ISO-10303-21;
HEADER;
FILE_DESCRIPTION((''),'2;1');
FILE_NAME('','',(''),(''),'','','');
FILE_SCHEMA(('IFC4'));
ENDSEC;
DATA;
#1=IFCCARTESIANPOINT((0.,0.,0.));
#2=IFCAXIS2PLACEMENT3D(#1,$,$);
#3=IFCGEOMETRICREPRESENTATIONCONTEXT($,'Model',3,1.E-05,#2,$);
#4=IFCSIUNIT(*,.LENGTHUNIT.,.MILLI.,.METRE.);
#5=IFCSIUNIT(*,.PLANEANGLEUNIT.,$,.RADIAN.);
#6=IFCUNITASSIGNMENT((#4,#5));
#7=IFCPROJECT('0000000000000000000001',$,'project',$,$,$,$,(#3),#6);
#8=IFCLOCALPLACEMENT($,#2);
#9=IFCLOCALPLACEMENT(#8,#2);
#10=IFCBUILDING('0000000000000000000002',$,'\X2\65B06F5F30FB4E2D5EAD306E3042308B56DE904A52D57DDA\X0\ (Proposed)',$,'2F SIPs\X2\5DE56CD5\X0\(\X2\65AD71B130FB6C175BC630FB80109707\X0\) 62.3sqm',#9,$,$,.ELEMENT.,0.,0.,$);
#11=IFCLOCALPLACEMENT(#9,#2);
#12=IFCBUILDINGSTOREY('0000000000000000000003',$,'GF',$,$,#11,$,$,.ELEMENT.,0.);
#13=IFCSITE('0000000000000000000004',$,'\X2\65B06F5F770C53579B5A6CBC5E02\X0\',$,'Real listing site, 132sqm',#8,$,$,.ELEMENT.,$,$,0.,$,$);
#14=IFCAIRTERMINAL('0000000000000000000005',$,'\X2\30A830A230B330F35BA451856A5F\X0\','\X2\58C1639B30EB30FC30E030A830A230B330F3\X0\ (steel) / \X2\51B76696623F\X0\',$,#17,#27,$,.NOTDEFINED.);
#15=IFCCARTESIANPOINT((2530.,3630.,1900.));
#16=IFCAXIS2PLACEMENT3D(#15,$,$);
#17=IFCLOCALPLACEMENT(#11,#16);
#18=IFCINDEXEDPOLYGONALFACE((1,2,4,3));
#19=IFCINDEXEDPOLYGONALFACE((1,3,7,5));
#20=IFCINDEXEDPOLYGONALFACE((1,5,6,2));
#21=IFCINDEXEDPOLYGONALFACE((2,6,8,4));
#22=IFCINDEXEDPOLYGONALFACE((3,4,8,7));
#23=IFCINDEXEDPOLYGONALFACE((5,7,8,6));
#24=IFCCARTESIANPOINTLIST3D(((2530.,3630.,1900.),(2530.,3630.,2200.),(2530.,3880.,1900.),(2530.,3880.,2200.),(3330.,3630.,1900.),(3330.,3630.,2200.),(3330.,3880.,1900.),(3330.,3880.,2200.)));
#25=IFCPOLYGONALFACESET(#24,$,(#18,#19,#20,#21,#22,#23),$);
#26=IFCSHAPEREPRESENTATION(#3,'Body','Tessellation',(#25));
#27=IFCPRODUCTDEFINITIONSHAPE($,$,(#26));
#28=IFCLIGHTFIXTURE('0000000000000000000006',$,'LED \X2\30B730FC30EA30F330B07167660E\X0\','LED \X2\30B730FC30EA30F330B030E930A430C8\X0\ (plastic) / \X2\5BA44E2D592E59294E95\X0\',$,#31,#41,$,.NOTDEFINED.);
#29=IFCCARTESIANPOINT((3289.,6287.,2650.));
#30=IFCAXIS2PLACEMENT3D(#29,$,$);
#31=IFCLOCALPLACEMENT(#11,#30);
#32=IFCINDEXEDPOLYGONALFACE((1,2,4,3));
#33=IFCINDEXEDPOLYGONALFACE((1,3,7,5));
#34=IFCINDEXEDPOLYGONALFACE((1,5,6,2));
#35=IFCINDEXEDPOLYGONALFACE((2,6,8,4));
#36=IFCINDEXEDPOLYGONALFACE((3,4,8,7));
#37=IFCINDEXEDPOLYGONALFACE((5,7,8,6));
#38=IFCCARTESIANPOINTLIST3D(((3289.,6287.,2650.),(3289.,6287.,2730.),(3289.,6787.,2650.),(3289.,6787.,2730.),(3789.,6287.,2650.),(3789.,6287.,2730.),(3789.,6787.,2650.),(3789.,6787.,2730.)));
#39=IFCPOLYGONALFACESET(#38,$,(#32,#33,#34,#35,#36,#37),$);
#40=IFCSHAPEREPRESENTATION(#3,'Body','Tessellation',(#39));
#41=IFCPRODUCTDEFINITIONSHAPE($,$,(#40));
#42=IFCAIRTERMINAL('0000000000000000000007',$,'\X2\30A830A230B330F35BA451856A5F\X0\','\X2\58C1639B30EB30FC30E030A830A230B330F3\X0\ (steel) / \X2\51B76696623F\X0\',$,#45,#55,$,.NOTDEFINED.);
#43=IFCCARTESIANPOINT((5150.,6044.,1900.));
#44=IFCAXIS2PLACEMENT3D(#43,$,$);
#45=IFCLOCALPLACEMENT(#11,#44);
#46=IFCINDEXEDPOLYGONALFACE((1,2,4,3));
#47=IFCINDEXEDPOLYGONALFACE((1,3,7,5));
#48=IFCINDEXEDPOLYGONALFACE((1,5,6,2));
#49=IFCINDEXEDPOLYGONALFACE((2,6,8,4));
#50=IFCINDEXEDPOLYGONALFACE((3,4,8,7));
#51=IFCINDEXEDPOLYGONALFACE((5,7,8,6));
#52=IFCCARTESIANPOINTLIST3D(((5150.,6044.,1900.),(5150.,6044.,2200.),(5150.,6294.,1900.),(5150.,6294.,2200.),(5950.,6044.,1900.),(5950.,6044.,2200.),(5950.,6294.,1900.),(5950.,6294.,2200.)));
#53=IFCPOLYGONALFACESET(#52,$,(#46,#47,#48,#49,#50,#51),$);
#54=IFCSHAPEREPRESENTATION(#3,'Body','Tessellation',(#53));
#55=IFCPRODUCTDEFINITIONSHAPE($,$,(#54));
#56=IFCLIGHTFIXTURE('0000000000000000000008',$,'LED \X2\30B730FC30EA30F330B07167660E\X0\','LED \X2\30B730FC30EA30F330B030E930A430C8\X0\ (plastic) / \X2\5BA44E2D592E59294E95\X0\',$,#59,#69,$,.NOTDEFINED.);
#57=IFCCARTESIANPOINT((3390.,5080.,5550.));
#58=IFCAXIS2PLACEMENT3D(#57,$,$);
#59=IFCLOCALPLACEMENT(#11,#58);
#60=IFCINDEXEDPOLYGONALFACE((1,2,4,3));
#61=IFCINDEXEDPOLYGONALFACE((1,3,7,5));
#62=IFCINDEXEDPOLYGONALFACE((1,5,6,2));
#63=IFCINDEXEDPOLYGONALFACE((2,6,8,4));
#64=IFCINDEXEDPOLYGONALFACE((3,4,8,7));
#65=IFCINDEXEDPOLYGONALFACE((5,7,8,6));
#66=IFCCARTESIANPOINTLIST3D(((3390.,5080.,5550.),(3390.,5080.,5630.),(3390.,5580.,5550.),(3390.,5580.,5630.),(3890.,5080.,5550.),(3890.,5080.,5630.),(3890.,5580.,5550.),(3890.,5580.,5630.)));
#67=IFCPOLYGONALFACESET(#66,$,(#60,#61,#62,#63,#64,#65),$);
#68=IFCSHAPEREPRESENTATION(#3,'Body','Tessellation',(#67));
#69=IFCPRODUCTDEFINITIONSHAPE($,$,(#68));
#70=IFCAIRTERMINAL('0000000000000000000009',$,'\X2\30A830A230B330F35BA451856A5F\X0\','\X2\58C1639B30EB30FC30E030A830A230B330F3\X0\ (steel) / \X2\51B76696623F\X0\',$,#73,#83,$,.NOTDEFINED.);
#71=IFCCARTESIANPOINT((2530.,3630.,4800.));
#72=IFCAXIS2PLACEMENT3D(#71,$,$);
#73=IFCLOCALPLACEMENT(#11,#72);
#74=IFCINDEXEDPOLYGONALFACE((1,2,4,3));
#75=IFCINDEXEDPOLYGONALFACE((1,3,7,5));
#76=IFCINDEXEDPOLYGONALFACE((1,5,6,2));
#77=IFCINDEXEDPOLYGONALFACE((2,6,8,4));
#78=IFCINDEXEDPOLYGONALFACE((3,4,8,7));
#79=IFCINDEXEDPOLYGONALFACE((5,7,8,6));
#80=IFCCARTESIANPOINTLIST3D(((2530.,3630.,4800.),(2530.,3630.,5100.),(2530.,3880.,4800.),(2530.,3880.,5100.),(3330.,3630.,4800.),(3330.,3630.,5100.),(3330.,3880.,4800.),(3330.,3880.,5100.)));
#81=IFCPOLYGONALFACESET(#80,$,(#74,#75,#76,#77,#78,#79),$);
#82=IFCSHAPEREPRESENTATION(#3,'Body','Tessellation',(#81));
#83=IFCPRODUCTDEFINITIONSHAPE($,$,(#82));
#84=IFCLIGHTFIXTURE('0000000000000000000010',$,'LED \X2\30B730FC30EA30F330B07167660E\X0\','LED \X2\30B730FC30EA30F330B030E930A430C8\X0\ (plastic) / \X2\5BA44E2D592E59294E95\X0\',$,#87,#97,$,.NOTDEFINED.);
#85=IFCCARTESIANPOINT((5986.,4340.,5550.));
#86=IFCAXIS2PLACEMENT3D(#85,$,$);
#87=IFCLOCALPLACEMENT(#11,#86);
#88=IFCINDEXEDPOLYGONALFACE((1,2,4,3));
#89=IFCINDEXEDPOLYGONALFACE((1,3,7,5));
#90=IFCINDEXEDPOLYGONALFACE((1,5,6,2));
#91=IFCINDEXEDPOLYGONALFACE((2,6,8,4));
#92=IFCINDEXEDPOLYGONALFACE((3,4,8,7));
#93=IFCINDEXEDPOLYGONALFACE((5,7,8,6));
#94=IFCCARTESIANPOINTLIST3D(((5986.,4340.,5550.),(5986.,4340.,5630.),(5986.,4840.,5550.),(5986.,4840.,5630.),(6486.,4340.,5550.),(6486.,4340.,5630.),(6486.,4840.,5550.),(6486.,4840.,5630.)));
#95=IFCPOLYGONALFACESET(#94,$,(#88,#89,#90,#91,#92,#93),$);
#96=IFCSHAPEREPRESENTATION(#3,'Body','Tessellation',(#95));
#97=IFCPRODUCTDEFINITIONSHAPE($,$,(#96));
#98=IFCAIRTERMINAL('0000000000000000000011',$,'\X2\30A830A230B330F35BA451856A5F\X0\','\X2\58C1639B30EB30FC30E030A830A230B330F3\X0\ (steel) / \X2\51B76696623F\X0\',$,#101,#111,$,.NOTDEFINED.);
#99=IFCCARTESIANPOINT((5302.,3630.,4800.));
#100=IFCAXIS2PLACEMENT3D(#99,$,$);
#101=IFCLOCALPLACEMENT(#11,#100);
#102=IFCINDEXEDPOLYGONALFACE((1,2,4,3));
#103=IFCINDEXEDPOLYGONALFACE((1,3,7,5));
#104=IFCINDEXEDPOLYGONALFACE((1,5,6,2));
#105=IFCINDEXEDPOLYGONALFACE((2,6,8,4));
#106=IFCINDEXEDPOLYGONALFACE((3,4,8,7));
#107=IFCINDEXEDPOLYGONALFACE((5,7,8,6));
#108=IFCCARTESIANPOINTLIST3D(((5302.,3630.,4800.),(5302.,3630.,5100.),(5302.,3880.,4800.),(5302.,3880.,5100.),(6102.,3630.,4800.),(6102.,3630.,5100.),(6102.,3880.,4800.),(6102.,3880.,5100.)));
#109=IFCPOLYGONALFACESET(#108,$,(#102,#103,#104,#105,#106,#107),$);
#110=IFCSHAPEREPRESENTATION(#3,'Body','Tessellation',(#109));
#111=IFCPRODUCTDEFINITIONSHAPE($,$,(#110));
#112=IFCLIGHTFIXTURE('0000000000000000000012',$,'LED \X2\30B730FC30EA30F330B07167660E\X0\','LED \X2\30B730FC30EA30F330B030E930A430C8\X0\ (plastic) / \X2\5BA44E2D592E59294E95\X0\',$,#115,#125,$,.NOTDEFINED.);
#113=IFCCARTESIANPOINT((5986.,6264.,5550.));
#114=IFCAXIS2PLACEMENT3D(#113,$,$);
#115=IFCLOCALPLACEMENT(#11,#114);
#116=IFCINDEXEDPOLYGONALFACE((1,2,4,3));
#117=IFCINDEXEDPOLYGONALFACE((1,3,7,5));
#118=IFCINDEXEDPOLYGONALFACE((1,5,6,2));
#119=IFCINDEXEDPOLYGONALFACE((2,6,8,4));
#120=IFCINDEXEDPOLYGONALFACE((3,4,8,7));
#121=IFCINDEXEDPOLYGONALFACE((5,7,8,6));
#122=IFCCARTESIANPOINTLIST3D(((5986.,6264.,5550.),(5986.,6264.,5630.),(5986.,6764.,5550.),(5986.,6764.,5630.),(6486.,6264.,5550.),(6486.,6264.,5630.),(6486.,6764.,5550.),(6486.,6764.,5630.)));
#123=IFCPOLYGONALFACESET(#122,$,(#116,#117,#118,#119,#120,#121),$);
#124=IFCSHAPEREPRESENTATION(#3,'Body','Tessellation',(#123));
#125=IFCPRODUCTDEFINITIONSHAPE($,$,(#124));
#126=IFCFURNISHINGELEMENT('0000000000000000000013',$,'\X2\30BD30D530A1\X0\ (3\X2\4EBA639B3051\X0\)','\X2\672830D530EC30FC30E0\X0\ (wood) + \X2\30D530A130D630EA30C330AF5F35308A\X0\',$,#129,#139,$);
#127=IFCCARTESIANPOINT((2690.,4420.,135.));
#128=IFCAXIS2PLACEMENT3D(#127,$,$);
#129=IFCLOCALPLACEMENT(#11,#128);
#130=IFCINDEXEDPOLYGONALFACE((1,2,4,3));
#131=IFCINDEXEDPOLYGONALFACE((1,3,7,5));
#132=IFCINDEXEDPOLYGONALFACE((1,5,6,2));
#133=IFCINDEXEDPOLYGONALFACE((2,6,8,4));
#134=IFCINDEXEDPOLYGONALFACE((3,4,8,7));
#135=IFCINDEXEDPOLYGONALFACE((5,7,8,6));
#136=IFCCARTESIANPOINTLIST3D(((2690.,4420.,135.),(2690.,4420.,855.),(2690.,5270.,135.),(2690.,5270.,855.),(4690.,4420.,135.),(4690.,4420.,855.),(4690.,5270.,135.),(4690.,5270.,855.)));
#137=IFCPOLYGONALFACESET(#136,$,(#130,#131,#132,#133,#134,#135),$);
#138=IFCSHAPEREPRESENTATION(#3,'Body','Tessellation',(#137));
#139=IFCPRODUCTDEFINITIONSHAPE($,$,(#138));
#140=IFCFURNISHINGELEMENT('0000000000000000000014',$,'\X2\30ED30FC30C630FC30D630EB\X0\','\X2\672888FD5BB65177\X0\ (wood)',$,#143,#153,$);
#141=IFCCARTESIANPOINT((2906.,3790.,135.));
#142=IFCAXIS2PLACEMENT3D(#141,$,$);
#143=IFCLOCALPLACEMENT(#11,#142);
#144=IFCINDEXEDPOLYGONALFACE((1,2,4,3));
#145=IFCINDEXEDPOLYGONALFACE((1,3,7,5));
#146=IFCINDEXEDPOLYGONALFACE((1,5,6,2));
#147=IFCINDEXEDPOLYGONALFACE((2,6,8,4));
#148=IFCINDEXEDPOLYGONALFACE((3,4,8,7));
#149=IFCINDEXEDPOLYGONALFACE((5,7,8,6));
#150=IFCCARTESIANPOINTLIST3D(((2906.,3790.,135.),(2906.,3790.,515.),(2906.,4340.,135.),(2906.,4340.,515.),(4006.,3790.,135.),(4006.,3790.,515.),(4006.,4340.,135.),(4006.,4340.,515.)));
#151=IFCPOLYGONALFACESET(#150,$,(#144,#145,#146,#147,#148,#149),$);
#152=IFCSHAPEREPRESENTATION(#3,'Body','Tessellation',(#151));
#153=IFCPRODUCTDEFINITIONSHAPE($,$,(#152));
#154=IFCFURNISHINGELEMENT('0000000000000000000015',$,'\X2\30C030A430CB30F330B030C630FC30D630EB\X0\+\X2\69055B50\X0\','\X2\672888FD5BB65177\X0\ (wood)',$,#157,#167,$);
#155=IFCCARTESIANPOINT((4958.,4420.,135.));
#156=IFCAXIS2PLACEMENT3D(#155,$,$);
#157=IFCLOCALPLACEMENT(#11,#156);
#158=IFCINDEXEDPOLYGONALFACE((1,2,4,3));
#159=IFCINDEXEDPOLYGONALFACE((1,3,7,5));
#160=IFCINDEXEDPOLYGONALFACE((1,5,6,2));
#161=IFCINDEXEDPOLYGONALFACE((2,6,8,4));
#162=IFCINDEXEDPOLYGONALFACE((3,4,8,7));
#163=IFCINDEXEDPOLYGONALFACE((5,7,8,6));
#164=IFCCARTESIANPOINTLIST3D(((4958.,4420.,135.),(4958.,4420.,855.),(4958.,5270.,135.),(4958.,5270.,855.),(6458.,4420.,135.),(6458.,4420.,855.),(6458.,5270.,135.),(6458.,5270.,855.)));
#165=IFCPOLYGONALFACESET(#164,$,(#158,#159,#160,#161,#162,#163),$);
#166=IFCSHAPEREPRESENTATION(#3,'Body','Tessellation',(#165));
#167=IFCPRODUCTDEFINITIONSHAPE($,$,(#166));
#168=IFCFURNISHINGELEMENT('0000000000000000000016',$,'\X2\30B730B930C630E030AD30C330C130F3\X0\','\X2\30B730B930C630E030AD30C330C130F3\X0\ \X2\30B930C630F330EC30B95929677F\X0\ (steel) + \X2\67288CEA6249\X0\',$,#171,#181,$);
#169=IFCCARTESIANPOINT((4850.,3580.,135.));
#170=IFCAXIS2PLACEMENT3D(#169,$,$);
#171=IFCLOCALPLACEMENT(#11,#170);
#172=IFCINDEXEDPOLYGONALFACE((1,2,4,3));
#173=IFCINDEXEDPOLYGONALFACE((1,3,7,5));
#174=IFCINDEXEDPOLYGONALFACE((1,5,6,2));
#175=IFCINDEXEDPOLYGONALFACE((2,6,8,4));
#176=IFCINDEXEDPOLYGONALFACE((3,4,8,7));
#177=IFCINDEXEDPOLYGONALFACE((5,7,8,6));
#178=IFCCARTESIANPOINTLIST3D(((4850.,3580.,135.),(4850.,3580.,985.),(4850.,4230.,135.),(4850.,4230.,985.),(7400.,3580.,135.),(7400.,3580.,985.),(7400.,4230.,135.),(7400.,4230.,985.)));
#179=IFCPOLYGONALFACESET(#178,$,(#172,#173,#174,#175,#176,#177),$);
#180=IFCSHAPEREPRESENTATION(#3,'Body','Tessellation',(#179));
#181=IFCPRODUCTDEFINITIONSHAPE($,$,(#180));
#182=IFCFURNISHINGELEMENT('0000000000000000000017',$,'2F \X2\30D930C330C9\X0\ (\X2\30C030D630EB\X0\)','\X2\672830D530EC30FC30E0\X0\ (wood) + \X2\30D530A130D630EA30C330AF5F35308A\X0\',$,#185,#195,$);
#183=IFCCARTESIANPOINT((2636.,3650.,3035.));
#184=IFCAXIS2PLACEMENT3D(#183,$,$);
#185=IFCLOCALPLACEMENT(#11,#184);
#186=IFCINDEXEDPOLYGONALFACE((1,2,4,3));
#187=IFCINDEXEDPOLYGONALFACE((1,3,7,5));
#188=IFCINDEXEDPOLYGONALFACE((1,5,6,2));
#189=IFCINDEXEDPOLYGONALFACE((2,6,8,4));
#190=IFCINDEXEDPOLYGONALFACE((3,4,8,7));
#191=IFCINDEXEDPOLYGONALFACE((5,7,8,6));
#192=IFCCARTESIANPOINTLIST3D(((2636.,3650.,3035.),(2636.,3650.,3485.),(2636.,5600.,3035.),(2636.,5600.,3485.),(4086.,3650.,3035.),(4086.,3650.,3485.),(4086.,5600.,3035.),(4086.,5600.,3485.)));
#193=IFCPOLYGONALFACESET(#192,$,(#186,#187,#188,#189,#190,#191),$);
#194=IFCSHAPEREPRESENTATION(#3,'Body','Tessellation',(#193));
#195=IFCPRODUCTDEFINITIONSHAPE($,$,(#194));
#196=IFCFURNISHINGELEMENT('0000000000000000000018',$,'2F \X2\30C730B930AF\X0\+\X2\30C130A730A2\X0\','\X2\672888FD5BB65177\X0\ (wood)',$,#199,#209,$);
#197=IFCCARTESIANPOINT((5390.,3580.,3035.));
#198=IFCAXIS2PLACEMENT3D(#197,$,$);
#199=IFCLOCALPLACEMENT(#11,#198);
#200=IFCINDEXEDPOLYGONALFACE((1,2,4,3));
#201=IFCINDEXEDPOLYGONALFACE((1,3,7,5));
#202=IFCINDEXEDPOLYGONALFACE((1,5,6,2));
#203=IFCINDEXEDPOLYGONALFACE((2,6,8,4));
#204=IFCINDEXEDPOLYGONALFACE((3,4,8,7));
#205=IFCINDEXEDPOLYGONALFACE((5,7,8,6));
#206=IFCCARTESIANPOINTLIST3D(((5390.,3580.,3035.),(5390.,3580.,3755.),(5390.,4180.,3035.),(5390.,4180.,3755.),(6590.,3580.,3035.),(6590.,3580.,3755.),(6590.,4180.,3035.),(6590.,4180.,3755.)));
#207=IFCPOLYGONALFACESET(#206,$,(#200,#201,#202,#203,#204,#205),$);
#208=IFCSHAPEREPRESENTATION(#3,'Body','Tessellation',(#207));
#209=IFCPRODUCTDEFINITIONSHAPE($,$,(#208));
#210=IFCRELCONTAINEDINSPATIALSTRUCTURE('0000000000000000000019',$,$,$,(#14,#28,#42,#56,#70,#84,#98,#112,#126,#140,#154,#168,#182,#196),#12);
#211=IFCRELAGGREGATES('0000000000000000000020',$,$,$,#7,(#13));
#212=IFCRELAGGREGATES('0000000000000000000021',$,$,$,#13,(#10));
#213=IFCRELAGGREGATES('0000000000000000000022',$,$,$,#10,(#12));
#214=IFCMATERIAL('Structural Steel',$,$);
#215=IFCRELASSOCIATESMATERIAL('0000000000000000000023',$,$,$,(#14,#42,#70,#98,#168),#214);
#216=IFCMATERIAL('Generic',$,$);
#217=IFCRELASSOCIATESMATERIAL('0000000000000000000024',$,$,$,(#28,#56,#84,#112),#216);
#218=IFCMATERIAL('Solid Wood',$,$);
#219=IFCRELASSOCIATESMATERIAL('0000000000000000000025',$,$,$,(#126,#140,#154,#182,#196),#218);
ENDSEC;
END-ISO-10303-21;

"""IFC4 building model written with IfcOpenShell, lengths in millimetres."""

from ifc_helpers import new_model, si_unit, frame, frame_2d, origin, place, context, project, spatial, rectangle, extrude, material, element, save


model = new_model("IFC4")

# Units and contexts
model_context = context("Model", 3, precision=1e-05, world=origin())
ifc_project = project(units=[si_unit("LENGTHUNIT", "METRE", prefix="MILLI"), si_unit("PLANEANGLEUNIT", "RADIAN")], contexts=[model_context])

# Site, building, storey
site_placement = place(None, origin())
site = spatial("IfcSite", under=ifc_project, at=site_placement, Name="新潟県南魚沼市", ObjectType="Real listing site, 132sqm", CompositionType="ELEMENT", RefElevation=0.0)
building_placement = place(site_placement, origin())
building = spatial("IfcBuilding", under=site, at=building_placement, Name="新潟・中庭のある回遊動線 (Proposed)", ObjectType="2F SIPs工法(断熱・気密・耐震) 62.3sqm", CompositionType="ELEMENT", ElevationOfRefHeight=0.0, ElevationOfTerrain=0.0)
storey_placement = place(building_placement, origin())
storey = spatial("IfcBuildingStorey", under=building, at=storey_placement, Name="GF", CompositionType="ELEMENT", Elevation=0.0)

# Shared definitions
ifc_material_1 = material(Name="Solid Wood")

# Shared definitions
ifc_material_2 = material(Name="Structural Steel")

# Shared definitions
ifc_material_3 = material(Name="Generic")

# Air terminal
air_terminal_1_placement = place(storey_placement, frame((2530.0, 3630.0, 1900.0)))
element("IfcAirTerminal", 1, at=air_terminal_1_placement, inside=storey, material=ifc_material_2, Name="エアコン室内機", Description="壁掛ルームエアコン (steel) / 冷暖房", PredefinedType="NOTDEFINED", context=model_context, shape_type="SweptSolid", body=[
    extrude(rectangle(XDim=800.0, YDim=250.0, at=frame_2d((400.0, 125.0))), frame((2530.0, 3630.0, 1900.0)), (0.0, 0.0, 1.0), 300.0),
])

# Light fixture
light_fixture_1_placement = place(storey_placement, frame((3289.0, 6287.0, 2650.0)))
element("IfcLightFixture", 2, at=light_fixture_1_placement, inside=storey, material=ifc_material_3, Name="LED シーリング照明", Description="LED シーリングライト (plastic) / 室中央天井", PredefinedType="NOTDEFINED", context=model_context, shape_type="SweptSolid", body=[
    extrude(rectangle(XDim=500.0, YDim=500.0, at=frame_2d((250.0, 250.0))), frame((3289.0, 6287.0, 2650.0)), (0.0, 0.0, 1.0), 80.0),
])

# Air terminal
air_terminal_2_placement = place(storey_placement, frame((5150.0, 6044.0, 1900.0)))
element("IfcAirTerminal", 3, at=air_terminal_2_placement, inside=storey, material=ifc_material_2, Name="エアコン室内機", Description="壁掛ルームエアコン (steel) / 冷暖房", PredefinedType="NOTDEFINED", context=model_context, shape_type="SweptSolid", body=[
    extrude(rectangle(XDim=800.0, YDim=250.0, at=frame_2d((400.0, 125.0))), frame((5150.0, 6044.0, 1900.0)), (0.0, 0.0, 1.0), 300.0),
])

# Light fixture
light_fixture_2_placement = place(storey_placement, frame((3390.0, 5080.0, 5550.0)))
element("IfcLightFixture", 4, at=light_fixture_2_placement, inside=storey, material=ifc_material_3, Name="LED シーリング照明", Description="LED シーリングライト (plastic) / 室中央天井", PredefinedType="NOTDEFINED", context=model_context, shape_type="SweptSolid", body=[
    extrude(rectangle(XDim=500.0, YDim=500.0, at=frame_2d((250.0, 250.0))), frame((3390.0, 5080.0, 5550.0)), (0.0, 0.0, 1.0), 80.0),
])

# Air terminal
air_terminal_3_placement = place(storey_placement, frame((2530.0, 3630.0, 4800.0)))
element("IfcAirTerminal", 5, at=air_terminal_3_placement, inside=storey, material=ifc_material_2, Name="エアコン室内機", Description="壁掛ルームエアコン (steel) / 冷暖房", PredefinedType="NOTDEFINED", context=model_context, shape_type="SweptSolid", body=[
    extrude(rectangle(XDim=800.0, YDim=250.0, at=frame_2d((400.0, 125.0))), frame((2530.0, 3630.0, 4800.0)), (0.0, 0.0, 1.0), 300.0),
])

# Light fixture
light_fixture_3_placement = place(storey_placement, frame((5986.0, 4340.0, 5550.0)))
element("IfcLightFixture", 6, at=light_fixture_3_placement, inside=storey, material=ifc_material_3, Name="LED シーリング照明", Description="LED シーリングライト (plastic) / 室中央天井", PredefinedType="NOTDEFINED", context=model_context, shape_type="SweptSolid", body=[
    extrude(rectangle(XDim=500.0, YDim=500.0, at=frame_2d((250.0, 250.0))), frame((5986.0, 4340.0, 5550.0)), (0.0, 0.0, 1.0), 80.0),
])

# Air terminal
air_terminal_4_placement = place(storey_placement, frame((5302.0, 3630.0, 4800.0)))
element("IfcAirTerminal", 7, at=air_terminal_4_placement, inside=storey, material=ifc_material_2, Name="エアコン室内機", Description="壁掛ルームエアコン (steel) / 冷暖房", PredefinedType="NOTDEFINED", context=model_context, shape_type="SweptSolid", body=[
    extrude(rectangle(XDim=800.0, YDim=250.0, at=frame_2d((400.0, 125.0))), frame((5302.0, 3630.0, 4800.0)), (0.0, 0.0, 1.0), 300.0),
])

# Light fixture
light_fixture_4_placement = place(storey_placement, frame((5986.0, 6264.0, 5550.0)))
element("IfcLightFixture", 8, at=light_fixture_4_placement, inside=storey, material=ifc_material_3, Name="LED シーリング照明", Description="LED シーリングライト (plastic) / 室中央天井", PredefinedType="NOTDEFINED", context=model_context, shape_type="SweptSolid", body=[
    extrude(rectangle(XDim=500.0, YDim=500.0, at=frame_2d((250.0, 250.0))), frame((5986.0, 6264.0, 5550.0)), (0.0, 0.0, 1.0), 80.0),
])

# Furnishing elements
furnishing_1_placement = place(storey_placement, frame((2690.0, 4420.0, 135.0)))
element("IfcFurnishingElement", 9, at=furnishing_1_placement, inside=storey, material=ifc_material_1, Name="ソファ (3人掛け)", Description="木フレーム (wood) + ファブリック張り", context=model_context, shape_type="SweptSolid", body=[
    extrude(rectangle(XDim=2000.0, YDim=850.0, at=frame_2d((1000.0, 425.0))), frame((2690.0, 4420.0, 135.0)), (0.0, 0.0, 1.0), 720.0),
])
furnishing_2_placement = place(storey_placement, frame((2906.0, 3790.0, 135.0)))
element("IfcFurnishingElement", 10, at=furnishing_2_placement, inside=storey, material=ifc_material_1, Name="ローテーブル", Description="木製家具 (wood)", context=model_context, shape_type="SweptSolid", body=[
    extrude(rectangle(XDim=1100.0, YDim=550.0, at=frame_2d((550.0, 275.0))), frame((2906.0, 3790.0, 135.0)), (0.0, 0.0, 1.0), 380.0),
])
furnishing_3_placement = place(storey_placement, frame((4958.0, 4420.0, 135.0)))
element("IfcFurnishingElement", 11, at=furnishing_3_placement, inside=storey, material=ifc_material_1, Name="ダイニングテーブル+椅子", Description="木製家具 (wood)", context=model_context, shape_type="SweptSolid", body=[
    extrude(rectangle(XDim=1500.0, YDim=850.0, at=frame_2d((750.0, 425.0))), frame((4958.0, 4420.0, 135.0)), (0.0, 0.0, 1.0), 720.0),
])
furnishing_4_placement = place(storey_placement, frame((4850.0, 3580.0, 135.0)))
element("IfcFurnishingElement", 12, at=furnishing_4_placement, inside=storey, material=ifc_material_2, Name="システムキッチン", Description="システムキッチン ステンレス天板 (steel) + 木質扉", context=model_context, shape_type="SweptSolid", body=[
    extrude(rectangle(XDim=2550.0, YDim=650.0, at=frame_2d((1275.0, 325.0))), frame((4850.0, 3580.0, 135.0)), (0.0, 0.0, 1.0), 850.0),
])
furnishing_5_placement = place(storey_placement, frame((2636.0, 3650.0, 3035.0)))
element("IfcFurnishingElement", 13, at=furnishing_5_placement, inside=storey, material=ifc_material_1, Name="2F ベッド (ダブル)", Description="木フレーム (wood) + ファブリック張り", context=model_context, shape_type="SweptSolid", body=[
    extrude(rectangle(XDim=1450.0, YDim=1950.0, at=frame_2d((725.0, 975.0))), frame((2636.0, 3650.0, 3035.0)), (0.0, 0.0, 1.0), 450.0),
])
furnishing_6_placement = place(storey_placement, frame((5390.0, 3580.0, 3035.0)))
element("IfcFurnishingElement", 14, at=furnishing_6_placement, inside=storey, material=ifc_material_1, Name="2F デスク+チェア", Description="木製家具 (wood)", context=model_context, shape_type="SweptSolid", body=[
    extrude(rectangle(XDim=1200.0, YDim=600.0, at=frame_2d((600.0, 300.0))), frame((5390.0, 3580.0, 3035.0)), (0.0, 0.0, 1.0), 720.0),
])

save(model, "model.ifc")
